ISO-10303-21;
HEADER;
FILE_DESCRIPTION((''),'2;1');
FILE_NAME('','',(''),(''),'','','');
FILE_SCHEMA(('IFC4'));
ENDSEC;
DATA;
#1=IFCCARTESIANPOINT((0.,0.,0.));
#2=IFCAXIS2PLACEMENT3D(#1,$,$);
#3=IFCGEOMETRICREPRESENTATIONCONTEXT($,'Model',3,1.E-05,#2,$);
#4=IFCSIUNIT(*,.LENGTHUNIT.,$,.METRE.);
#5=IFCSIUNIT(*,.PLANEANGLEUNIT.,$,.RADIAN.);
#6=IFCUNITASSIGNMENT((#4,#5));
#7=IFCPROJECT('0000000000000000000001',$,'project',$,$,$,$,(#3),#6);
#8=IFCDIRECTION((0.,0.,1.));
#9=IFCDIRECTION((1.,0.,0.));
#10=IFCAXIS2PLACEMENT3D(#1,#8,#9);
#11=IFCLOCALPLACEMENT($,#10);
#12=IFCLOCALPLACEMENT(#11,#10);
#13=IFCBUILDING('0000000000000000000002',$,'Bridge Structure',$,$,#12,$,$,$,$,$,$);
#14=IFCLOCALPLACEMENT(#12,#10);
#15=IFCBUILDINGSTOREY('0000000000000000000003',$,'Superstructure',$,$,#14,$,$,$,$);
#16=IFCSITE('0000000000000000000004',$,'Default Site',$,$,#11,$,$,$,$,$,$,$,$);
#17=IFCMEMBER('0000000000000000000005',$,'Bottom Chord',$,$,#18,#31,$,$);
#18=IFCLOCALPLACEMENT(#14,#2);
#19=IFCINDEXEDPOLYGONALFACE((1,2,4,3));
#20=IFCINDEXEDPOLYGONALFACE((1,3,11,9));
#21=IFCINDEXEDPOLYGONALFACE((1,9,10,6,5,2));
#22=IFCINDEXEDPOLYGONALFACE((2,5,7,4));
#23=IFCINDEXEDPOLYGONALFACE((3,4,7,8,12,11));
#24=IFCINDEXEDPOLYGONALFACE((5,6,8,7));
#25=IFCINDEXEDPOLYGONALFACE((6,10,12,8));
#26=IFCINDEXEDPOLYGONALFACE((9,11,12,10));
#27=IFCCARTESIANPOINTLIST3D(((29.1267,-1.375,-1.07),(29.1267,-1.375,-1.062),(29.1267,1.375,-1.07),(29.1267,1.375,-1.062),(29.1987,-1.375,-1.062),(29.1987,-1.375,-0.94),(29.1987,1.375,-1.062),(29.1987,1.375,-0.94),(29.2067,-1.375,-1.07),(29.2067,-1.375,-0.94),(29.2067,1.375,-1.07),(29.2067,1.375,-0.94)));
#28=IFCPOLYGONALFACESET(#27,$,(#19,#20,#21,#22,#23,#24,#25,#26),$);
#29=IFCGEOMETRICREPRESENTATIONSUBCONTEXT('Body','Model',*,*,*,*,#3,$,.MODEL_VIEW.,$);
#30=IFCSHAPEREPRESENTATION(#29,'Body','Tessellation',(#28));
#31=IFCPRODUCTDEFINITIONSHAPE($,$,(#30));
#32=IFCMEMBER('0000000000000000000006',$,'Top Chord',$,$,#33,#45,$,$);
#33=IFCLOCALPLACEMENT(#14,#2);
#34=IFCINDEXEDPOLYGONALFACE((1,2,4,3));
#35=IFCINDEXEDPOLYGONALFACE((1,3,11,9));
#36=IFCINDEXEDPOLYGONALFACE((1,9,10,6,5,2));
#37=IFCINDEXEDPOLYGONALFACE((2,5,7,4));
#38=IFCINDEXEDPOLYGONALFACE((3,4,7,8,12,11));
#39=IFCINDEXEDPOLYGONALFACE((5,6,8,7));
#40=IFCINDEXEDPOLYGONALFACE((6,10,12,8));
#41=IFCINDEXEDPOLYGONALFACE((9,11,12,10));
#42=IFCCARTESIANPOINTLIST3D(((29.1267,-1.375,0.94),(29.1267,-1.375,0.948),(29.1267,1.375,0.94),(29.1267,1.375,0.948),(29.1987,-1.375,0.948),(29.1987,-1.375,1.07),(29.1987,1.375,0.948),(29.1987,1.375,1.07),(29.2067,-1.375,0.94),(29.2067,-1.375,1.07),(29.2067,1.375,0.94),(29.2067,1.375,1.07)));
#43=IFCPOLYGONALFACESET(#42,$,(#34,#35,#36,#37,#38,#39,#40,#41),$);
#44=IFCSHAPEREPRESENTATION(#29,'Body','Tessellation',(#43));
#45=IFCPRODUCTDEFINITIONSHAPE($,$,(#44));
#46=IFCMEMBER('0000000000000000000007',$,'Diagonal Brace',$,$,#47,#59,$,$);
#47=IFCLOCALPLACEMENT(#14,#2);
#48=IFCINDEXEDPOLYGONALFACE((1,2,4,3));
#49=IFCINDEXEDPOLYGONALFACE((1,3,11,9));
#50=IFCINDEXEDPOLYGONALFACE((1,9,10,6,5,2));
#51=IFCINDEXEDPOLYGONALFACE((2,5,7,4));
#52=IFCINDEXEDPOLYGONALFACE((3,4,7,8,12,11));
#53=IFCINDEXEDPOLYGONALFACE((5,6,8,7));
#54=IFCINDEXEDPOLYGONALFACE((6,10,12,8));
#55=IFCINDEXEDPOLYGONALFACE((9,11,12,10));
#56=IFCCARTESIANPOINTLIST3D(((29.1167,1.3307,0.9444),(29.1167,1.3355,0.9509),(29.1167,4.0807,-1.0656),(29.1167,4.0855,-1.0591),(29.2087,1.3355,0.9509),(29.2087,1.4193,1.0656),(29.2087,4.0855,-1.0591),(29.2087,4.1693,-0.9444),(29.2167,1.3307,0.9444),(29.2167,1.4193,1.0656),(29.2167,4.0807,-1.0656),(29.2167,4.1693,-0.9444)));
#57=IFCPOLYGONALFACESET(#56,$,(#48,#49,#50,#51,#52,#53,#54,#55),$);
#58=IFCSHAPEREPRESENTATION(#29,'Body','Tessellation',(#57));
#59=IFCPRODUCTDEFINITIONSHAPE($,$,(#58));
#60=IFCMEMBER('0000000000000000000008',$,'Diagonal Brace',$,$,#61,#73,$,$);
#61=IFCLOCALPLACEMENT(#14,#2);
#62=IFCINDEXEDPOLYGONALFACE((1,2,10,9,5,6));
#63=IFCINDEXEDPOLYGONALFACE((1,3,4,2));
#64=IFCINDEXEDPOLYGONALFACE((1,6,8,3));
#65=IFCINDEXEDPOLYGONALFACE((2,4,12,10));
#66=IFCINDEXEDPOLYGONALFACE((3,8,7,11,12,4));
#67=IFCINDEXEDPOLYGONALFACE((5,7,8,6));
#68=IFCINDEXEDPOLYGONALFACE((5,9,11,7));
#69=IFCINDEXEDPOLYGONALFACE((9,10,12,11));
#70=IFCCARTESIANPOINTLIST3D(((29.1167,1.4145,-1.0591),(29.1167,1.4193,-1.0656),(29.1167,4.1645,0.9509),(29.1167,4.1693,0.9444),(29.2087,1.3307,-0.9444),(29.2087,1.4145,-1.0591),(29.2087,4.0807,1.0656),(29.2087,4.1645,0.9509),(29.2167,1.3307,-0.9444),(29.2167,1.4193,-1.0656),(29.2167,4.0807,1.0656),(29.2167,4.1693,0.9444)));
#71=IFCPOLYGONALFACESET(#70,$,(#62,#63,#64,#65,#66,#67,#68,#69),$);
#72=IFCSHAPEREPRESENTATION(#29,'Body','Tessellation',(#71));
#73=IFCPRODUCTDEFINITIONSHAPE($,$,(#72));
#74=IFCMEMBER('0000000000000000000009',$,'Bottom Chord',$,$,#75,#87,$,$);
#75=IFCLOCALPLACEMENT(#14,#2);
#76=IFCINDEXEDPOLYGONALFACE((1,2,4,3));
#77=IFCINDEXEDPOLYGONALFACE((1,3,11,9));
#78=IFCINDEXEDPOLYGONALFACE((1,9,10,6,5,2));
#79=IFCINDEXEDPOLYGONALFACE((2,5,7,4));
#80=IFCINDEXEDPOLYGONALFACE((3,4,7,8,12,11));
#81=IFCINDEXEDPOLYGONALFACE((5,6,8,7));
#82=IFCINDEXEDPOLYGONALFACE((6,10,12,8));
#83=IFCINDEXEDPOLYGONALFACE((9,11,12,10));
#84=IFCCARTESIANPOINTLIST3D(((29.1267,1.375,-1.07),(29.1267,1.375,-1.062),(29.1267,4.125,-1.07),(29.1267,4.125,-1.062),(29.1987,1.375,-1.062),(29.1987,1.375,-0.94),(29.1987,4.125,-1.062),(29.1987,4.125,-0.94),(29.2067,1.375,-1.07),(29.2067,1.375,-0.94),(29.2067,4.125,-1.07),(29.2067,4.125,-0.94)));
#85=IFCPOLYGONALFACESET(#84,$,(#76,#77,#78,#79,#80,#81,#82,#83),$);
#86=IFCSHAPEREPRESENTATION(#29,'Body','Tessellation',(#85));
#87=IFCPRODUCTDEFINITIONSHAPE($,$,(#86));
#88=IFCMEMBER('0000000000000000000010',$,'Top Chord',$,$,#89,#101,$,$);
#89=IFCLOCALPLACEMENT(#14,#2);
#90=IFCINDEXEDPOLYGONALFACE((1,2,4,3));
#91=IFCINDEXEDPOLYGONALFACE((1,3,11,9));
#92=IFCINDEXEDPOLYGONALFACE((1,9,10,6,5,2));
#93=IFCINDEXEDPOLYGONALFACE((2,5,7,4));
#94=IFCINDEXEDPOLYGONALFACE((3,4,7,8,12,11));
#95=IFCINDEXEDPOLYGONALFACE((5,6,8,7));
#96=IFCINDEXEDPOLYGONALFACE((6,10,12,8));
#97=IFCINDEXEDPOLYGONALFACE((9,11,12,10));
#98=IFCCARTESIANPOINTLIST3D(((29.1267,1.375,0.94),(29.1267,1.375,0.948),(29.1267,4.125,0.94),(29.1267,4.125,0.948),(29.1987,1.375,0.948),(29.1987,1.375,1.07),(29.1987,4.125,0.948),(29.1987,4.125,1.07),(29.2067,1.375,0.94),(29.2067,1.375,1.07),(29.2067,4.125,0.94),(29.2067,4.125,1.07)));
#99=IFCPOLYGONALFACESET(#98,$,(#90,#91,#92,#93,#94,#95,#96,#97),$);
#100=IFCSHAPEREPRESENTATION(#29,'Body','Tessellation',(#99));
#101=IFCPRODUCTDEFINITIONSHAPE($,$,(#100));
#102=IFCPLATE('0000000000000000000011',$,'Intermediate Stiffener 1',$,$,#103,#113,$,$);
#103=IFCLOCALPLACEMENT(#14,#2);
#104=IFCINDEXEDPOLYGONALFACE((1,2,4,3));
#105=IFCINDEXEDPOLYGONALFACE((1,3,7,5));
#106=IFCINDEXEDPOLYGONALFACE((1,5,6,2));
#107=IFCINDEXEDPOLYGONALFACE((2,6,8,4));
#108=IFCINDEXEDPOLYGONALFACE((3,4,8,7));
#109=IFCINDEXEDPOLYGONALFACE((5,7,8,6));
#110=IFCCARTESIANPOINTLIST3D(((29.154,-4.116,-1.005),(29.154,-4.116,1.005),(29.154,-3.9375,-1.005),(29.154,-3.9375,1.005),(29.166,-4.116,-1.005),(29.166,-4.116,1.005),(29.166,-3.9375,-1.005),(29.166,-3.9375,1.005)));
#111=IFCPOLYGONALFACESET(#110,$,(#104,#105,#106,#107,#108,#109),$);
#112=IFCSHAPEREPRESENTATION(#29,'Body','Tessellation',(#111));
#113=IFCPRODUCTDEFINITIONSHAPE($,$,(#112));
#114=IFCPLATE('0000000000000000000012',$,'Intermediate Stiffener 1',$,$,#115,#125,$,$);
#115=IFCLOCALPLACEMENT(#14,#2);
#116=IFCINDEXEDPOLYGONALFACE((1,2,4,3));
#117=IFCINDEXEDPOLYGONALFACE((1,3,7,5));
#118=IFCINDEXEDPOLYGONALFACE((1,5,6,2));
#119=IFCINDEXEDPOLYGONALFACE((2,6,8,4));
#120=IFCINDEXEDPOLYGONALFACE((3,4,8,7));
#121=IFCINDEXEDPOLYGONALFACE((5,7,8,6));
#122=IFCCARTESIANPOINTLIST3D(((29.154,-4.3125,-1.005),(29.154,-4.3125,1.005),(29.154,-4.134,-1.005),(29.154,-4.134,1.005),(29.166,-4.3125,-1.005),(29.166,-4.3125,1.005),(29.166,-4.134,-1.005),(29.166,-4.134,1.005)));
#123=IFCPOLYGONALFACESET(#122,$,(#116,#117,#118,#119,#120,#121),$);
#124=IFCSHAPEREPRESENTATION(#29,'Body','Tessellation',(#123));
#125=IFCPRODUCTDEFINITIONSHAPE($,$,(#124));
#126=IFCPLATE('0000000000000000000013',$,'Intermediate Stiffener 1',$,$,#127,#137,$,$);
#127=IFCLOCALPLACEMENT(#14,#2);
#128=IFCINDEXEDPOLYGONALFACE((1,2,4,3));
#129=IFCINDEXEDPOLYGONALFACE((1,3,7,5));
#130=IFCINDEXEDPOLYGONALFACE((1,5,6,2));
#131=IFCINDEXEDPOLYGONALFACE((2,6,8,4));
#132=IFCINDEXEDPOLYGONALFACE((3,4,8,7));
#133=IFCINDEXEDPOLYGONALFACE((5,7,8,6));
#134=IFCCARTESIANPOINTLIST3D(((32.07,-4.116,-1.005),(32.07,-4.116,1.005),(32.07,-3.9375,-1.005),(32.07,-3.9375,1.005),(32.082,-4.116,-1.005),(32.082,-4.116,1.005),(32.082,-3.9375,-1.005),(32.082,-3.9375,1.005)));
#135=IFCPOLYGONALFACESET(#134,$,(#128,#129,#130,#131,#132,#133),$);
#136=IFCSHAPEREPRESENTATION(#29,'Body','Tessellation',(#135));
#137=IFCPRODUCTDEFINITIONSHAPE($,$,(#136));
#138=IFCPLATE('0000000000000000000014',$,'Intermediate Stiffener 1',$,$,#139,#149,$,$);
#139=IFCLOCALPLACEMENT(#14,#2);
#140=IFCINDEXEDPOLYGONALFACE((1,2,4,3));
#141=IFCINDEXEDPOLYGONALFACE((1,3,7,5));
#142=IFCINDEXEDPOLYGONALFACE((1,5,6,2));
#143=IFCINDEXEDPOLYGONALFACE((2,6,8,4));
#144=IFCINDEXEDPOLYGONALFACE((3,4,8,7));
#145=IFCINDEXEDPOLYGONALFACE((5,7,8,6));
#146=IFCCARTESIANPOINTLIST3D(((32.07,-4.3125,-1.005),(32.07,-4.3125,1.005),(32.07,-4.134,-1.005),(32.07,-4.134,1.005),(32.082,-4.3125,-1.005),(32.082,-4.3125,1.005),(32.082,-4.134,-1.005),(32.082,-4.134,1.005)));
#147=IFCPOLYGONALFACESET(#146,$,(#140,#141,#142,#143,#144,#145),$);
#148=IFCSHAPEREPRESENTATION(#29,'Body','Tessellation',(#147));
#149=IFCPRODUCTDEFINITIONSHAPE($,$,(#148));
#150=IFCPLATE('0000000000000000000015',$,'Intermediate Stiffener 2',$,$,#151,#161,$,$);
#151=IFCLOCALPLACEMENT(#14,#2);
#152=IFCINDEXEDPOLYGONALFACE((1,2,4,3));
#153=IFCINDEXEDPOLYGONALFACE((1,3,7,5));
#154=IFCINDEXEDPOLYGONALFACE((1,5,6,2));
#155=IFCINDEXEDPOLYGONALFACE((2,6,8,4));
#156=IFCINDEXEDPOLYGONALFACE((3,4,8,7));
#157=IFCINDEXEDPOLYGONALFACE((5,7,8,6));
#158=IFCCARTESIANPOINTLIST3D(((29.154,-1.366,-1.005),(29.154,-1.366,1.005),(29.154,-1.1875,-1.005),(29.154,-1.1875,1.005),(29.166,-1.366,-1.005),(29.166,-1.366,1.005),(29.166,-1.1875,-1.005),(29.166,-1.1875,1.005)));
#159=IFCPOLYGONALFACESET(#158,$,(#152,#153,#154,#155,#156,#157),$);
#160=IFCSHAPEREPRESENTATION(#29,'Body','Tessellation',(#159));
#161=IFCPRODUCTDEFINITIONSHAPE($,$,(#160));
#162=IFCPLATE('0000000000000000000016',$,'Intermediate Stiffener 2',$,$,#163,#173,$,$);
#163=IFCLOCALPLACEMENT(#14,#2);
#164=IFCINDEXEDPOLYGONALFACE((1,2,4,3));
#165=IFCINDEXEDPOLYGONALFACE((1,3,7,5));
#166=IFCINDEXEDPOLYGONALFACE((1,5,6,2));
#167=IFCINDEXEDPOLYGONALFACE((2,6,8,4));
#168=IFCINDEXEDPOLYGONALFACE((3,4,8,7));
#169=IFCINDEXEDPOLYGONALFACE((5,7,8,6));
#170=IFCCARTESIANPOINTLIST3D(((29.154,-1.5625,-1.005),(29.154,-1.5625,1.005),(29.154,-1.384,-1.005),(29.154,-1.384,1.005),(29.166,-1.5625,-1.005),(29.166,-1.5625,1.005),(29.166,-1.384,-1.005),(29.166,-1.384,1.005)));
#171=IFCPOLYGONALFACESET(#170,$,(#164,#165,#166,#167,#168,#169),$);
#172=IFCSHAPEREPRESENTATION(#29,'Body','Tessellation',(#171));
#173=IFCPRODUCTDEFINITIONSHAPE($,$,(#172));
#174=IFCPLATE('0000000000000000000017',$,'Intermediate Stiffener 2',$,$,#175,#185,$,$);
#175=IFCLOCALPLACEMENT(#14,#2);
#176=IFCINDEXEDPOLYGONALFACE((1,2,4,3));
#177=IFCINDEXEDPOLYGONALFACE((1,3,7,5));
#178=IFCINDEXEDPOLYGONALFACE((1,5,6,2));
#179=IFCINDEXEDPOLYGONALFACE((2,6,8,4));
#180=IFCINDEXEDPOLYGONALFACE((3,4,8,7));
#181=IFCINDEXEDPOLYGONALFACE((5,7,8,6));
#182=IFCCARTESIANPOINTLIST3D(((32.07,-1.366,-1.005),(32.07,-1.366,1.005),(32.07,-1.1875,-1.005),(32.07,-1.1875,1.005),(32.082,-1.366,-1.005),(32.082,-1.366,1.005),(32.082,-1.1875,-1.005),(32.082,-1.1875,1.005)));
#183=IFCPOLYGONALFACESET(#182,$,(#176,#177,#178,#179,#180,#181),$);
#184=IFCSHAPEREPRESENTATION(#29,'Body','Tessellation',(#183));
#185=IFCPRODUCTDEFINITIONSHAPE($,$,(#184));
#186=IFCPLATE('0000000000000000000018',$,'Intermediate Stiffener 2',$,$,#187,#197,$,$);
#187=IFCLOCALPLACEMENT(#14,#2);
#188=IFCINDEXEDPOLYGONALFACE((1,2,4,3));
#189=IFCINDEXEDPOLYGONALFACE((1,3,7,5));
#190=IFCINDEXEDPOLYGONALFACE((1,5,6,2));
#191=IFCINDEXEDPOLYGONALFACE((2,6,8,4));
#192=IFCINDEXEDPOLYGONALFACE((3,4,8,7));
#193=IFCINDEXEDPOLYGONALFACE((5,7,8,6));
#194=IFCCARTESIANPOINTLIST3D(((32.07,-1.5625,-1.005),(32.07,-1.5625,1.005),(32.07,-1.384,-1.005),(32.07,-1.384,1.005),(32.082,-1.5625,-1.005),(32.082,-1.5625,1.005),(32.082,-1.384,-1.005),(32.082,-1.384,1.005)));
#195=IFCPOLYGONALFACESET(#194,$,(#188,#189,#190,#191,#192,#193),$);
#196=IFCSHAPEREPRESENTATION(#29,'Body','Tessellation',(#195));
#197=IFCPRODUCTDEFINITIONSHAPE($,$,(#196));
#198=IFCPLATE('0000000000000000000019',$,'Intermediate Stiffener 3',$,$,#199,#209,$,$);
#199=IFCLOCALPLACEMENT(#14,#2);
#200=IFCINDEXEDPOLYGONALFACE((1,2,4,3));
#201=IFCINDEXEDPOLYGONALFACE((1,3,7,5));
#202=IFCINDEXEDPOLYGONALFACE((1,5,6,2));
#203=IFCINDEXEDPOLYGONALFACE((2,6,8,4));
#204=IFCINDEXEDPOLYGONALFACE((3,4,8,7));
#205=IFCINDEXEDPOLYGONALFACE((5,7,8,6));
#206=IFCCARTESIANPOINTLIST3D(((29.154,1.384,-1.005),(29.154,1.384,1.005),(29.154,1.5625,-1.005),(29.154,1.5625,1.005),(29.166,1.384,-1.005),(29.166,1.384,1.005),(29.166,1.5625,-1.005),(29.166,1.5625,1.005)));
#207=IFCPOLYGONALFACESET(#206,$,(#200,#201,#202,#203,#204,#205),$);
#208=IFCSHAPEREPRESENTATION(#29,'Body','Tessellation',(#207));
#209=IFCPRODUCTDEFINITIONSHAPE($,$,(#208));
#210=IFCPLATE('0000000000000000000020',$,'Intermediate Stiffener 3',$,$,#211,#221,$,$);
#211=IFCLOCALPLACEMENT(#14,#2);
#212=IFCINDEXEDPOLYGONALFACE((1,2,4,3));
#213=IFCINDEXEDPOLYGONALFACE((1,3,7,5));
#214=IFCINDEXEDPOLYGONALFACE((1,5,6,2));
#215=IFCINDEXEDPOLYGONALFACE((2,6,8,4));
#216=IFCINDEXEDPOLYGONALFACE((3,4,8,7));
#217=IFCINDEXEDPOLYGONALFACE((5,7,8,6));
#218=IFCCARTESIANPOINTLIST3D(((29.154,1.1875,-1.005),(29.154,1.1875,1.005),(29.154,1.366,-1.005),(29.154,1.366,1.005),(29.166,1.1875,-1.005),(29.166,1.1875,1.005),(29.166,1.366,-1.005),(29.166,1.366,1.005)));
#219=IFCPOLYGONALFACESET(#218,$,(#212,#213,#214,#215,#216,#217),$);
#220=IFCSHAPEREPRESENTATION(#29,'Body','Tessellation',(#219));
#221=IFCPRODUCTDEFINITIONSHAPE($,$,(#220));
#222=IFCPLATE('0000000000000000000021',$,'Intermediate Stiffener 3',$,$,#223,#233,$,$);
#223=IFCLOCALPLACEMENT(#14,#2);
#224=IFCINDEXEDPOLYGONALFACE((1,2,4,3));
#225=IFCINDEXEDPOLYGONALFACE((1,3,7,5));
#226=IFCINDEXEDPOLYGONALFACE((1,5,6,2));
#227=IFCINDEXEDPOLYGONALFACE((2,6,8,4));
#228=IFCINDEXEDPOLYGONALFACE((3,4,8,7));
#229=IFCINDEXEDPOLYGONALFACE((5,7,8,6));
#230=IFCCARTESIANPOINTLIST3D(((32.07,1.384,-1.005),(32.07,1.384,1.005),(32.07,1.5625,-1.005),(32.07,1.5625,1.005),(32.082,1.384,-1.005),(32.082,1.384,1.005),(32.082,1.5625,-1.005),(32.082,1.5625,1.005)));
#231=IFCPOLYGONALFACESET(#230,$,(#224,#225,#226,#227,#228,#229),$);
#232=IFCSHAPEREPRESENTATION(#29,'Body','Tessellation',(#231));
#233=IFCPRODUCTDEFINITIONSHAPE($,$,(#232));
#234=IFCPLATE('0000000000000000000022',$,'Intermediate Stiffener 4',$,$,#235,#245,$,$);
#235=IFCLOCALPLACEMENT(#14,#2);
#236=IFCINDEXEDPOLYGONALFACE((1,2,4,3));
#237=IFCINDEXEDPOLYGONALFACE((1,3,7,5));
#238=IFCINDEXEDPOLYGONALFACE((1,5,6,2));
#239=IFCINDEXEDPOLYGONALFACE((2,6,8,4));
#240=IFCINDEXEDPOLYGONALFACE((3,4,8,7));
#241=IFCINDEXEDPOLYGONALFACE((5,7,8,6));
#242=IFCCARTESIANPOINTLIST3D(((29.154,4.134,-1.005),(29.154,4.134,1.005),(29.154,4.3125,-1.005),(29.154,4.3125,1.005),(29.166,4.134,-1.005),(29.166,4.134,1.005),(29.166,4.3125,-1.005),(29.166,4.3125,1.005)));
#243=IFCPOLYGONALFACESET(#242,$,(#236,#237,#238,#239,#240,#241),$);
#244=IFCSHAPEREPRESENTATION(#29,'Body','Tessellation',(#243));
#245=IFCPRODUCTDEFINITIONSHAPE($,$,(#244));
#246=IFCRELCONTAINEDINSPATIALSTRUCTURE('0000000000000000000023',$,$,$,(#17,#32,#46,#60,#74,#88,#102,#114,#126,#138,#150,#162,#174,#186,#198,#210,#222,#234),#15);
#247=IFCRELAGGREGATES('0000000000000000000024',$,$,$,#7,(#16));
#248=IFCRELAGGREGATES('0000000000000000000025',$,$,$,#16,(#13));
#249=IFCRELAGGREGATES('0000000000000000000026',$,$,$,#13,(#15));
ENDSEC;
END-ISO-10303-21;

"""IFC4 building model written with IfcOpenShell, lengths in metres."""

from ifc_helpers import new_model, si_unit, frame, origin, origin_with_axes, origin_2d_with_axis, place, context, subcontext, project, spatial, rectangle, l_section, extrude, element, save


model = new_model("IFC4")

# Units and contexts
model_context = context("Model", 3, precision=1e-05, world=origin())
body_context = subcontext(model_context, "Body", "Model", "MODEL_VIEW")
ifc_project = project(units=[si_unit("LENGTHUNIT", "METRE"), si_unit("PLANEANGLEUNIT", "RADIAN")], contexts=[model_context])

# Site, building, storey
site_placement = place(None, origin_with_axes())
site = spatial("IfcSite", under=ifc_project, at=site_placement, Name="Default Site")
building_placement = place(site_placement, origin_with_axes())
building = spatial("IfcBuilding", under=site, at=building_placement, Name="Bridge Structure")
storey_placement = place(building_placement, origin_with_axes())
storey = spatial("IfcBuildingStorey", under=building, at=storey_placement, Name="Superstructure")

# Members
for number, where, z_axis, x_axis, name in (
    (1, (29.1667, -1.375, -1.005), (0.0, 1.0, 0.0), (-1.0, 0.0, 0.0), "Bottom Chord"),
    (2, (29.1667, -1.375, 1.005), (0.0, 1.0, 0.0), (-1.0, 0.0, 0.0), "Top Chord"),
):
    element("IfcMember", number, at=place(storey_placement, frame(where, z_axis=z_axis, x_axis=x_axis)), inside=storey, Name=name, context=body_context, shape_type="SweptSolid", body=[
        extrude(l_section(Depth=0.13, Width=0.08, Thickness=0.008, at=origin_2d_with_axis()), origin_with_axes(), (0.0, 0.0, 1.0), 2.75),
    ])
for number, where, z_axis, x_axis, name in (
    (3, (29.1667, 1.375, 1.005), (0.0, 0.807337, -0.59009), (-1.0, 0.0, 0.0), "Diagonal Brace"),
    (4, (29.1667, 1.375, -1.005), (0.0, 0.807337, 0.59009), (-1.0, 0.0, 0.0), "Diagonal Brace"),
):
    element("IfcMember", number, at=place(storey_placement, frame(where, z_axis=z_axis, x_axis=x_axis)), inside=storey, Name=name, context=body_context, shape_type="SweptSolid", body=[
        extrude(l_section(Depth=0.15, Width=0.1, Thickness=0.008, at=origin_2d_with_axis()), origin_with_axes(), (0.0, 0.0, 1.0), 3.4063),
    ])
for number, where, z_axis, x_axis, name in (
    (5, (29.1667, 1.375, -1.005), (0.0, 1.0, 0.0), (-1.0, 0.0, 0.0), "Bottom Chord"),
    (6, (29.1667, 1.375, 1.005), (0.0, 1.0, 0.0), (-1.0, 0.0, 0.0), "Top Chord"),
):
    element("IfcMember", number, at=place(storey_placement, frame(where, z_axis=z_axis, x_axis=x_axis)), inside=storey, Name=name, context=body_context, shape_type="SweptSolid", body=[
        extrude(l_section(Depth=0.13, Width=0.08, Thickness=0.008, at=origin_2d_with_axis()), origin_with_axes(), (0.0, 0.0, 1.0), 2.75),
    ])

# Plates
for number, where, z_axis, x_axis, name in (
    (7, (29.16, -4.0267, -1.005), (0.0, 0.0, 1.0), (1.0, 0.0, 0.0), "Intermediate Stiffener 1"),
    (8, (29.16, -4.2233, -1.005), (0.0, 0.0, 1.0), (1.0, 0.0, 0.0), "Intermediate Stiffener 1"),
    (9, (32.076, -4.0267, -1.005), (0.0, 0.0, 1.0), (1.0, 0.0, 0.0), "Intermediate Stiffener 1"),
    (10, (32.076, -4.2233, -1.005), (0.0, 0.0, 1.0), (1.0, 0.0, 0.0), "Intermediate Stiffener 1"),
    (11, (29.16, -1.2768, -1.005), (0.0, 0.0, 1.0), (1.0, 0.0, 0.0), "Intermediate Stiffener 2"),
    (12, (29.16, -1.4732, -1.005), (0.0, 0.0, 1.0), (1.0, 0.0, 0.0), "Intermediate Stiffener 2"),
    (13, (32.076, -1.2768, -1.005), (0.0, 0.0, 1.0), (1.0, 0.0, 0.0), "Intermediate Stiffener 2"),
    (14, (32.076, -1.4732, -1.005), (0.0, 0.0, 1.0), (1.0, 0.0, 0.0), "Intermediate Stiffener 2"),
    (15, (29.16, 1.4732, -1.005), (0.0, 0.0, 1.0), (1.0, 0.0, 0.0), "Intermediate Stiffener 3"),
    (16, (29.16, 1.2768, -1.005), (0.0, 0.0, 1.0), (1.0, 0.0, 0.0), "Intermediate Stiffener 3"),
    (17, (32.076, 1.4732, -1.005), (0.0, 0.0, 1.0), (1.0, 0.0, 0.0), "Intermediate Stiffener 3"),
    (18, (29.16, 4.2233, -1.005), (0.0, 0.0, 1.0), (1.0, 0.0, 0.0), "Intermediate Stiffener 4"),
):
    element("IfcPlate", number, at=place(storey_placement, frame(where, z_axis=z_axis, x_axis=x_axis)), inside=storey, Name=name, context=body_context, shape_type="SweptSolid", body=[
        extrude(rectangle(XDim=0.012, YDim=0.1785, at=origin_2d_with_axis()), origin_with_axes(), (0.0, 0.0, 1.0), 2.01),
    ])

save(model, "model.ifc")
